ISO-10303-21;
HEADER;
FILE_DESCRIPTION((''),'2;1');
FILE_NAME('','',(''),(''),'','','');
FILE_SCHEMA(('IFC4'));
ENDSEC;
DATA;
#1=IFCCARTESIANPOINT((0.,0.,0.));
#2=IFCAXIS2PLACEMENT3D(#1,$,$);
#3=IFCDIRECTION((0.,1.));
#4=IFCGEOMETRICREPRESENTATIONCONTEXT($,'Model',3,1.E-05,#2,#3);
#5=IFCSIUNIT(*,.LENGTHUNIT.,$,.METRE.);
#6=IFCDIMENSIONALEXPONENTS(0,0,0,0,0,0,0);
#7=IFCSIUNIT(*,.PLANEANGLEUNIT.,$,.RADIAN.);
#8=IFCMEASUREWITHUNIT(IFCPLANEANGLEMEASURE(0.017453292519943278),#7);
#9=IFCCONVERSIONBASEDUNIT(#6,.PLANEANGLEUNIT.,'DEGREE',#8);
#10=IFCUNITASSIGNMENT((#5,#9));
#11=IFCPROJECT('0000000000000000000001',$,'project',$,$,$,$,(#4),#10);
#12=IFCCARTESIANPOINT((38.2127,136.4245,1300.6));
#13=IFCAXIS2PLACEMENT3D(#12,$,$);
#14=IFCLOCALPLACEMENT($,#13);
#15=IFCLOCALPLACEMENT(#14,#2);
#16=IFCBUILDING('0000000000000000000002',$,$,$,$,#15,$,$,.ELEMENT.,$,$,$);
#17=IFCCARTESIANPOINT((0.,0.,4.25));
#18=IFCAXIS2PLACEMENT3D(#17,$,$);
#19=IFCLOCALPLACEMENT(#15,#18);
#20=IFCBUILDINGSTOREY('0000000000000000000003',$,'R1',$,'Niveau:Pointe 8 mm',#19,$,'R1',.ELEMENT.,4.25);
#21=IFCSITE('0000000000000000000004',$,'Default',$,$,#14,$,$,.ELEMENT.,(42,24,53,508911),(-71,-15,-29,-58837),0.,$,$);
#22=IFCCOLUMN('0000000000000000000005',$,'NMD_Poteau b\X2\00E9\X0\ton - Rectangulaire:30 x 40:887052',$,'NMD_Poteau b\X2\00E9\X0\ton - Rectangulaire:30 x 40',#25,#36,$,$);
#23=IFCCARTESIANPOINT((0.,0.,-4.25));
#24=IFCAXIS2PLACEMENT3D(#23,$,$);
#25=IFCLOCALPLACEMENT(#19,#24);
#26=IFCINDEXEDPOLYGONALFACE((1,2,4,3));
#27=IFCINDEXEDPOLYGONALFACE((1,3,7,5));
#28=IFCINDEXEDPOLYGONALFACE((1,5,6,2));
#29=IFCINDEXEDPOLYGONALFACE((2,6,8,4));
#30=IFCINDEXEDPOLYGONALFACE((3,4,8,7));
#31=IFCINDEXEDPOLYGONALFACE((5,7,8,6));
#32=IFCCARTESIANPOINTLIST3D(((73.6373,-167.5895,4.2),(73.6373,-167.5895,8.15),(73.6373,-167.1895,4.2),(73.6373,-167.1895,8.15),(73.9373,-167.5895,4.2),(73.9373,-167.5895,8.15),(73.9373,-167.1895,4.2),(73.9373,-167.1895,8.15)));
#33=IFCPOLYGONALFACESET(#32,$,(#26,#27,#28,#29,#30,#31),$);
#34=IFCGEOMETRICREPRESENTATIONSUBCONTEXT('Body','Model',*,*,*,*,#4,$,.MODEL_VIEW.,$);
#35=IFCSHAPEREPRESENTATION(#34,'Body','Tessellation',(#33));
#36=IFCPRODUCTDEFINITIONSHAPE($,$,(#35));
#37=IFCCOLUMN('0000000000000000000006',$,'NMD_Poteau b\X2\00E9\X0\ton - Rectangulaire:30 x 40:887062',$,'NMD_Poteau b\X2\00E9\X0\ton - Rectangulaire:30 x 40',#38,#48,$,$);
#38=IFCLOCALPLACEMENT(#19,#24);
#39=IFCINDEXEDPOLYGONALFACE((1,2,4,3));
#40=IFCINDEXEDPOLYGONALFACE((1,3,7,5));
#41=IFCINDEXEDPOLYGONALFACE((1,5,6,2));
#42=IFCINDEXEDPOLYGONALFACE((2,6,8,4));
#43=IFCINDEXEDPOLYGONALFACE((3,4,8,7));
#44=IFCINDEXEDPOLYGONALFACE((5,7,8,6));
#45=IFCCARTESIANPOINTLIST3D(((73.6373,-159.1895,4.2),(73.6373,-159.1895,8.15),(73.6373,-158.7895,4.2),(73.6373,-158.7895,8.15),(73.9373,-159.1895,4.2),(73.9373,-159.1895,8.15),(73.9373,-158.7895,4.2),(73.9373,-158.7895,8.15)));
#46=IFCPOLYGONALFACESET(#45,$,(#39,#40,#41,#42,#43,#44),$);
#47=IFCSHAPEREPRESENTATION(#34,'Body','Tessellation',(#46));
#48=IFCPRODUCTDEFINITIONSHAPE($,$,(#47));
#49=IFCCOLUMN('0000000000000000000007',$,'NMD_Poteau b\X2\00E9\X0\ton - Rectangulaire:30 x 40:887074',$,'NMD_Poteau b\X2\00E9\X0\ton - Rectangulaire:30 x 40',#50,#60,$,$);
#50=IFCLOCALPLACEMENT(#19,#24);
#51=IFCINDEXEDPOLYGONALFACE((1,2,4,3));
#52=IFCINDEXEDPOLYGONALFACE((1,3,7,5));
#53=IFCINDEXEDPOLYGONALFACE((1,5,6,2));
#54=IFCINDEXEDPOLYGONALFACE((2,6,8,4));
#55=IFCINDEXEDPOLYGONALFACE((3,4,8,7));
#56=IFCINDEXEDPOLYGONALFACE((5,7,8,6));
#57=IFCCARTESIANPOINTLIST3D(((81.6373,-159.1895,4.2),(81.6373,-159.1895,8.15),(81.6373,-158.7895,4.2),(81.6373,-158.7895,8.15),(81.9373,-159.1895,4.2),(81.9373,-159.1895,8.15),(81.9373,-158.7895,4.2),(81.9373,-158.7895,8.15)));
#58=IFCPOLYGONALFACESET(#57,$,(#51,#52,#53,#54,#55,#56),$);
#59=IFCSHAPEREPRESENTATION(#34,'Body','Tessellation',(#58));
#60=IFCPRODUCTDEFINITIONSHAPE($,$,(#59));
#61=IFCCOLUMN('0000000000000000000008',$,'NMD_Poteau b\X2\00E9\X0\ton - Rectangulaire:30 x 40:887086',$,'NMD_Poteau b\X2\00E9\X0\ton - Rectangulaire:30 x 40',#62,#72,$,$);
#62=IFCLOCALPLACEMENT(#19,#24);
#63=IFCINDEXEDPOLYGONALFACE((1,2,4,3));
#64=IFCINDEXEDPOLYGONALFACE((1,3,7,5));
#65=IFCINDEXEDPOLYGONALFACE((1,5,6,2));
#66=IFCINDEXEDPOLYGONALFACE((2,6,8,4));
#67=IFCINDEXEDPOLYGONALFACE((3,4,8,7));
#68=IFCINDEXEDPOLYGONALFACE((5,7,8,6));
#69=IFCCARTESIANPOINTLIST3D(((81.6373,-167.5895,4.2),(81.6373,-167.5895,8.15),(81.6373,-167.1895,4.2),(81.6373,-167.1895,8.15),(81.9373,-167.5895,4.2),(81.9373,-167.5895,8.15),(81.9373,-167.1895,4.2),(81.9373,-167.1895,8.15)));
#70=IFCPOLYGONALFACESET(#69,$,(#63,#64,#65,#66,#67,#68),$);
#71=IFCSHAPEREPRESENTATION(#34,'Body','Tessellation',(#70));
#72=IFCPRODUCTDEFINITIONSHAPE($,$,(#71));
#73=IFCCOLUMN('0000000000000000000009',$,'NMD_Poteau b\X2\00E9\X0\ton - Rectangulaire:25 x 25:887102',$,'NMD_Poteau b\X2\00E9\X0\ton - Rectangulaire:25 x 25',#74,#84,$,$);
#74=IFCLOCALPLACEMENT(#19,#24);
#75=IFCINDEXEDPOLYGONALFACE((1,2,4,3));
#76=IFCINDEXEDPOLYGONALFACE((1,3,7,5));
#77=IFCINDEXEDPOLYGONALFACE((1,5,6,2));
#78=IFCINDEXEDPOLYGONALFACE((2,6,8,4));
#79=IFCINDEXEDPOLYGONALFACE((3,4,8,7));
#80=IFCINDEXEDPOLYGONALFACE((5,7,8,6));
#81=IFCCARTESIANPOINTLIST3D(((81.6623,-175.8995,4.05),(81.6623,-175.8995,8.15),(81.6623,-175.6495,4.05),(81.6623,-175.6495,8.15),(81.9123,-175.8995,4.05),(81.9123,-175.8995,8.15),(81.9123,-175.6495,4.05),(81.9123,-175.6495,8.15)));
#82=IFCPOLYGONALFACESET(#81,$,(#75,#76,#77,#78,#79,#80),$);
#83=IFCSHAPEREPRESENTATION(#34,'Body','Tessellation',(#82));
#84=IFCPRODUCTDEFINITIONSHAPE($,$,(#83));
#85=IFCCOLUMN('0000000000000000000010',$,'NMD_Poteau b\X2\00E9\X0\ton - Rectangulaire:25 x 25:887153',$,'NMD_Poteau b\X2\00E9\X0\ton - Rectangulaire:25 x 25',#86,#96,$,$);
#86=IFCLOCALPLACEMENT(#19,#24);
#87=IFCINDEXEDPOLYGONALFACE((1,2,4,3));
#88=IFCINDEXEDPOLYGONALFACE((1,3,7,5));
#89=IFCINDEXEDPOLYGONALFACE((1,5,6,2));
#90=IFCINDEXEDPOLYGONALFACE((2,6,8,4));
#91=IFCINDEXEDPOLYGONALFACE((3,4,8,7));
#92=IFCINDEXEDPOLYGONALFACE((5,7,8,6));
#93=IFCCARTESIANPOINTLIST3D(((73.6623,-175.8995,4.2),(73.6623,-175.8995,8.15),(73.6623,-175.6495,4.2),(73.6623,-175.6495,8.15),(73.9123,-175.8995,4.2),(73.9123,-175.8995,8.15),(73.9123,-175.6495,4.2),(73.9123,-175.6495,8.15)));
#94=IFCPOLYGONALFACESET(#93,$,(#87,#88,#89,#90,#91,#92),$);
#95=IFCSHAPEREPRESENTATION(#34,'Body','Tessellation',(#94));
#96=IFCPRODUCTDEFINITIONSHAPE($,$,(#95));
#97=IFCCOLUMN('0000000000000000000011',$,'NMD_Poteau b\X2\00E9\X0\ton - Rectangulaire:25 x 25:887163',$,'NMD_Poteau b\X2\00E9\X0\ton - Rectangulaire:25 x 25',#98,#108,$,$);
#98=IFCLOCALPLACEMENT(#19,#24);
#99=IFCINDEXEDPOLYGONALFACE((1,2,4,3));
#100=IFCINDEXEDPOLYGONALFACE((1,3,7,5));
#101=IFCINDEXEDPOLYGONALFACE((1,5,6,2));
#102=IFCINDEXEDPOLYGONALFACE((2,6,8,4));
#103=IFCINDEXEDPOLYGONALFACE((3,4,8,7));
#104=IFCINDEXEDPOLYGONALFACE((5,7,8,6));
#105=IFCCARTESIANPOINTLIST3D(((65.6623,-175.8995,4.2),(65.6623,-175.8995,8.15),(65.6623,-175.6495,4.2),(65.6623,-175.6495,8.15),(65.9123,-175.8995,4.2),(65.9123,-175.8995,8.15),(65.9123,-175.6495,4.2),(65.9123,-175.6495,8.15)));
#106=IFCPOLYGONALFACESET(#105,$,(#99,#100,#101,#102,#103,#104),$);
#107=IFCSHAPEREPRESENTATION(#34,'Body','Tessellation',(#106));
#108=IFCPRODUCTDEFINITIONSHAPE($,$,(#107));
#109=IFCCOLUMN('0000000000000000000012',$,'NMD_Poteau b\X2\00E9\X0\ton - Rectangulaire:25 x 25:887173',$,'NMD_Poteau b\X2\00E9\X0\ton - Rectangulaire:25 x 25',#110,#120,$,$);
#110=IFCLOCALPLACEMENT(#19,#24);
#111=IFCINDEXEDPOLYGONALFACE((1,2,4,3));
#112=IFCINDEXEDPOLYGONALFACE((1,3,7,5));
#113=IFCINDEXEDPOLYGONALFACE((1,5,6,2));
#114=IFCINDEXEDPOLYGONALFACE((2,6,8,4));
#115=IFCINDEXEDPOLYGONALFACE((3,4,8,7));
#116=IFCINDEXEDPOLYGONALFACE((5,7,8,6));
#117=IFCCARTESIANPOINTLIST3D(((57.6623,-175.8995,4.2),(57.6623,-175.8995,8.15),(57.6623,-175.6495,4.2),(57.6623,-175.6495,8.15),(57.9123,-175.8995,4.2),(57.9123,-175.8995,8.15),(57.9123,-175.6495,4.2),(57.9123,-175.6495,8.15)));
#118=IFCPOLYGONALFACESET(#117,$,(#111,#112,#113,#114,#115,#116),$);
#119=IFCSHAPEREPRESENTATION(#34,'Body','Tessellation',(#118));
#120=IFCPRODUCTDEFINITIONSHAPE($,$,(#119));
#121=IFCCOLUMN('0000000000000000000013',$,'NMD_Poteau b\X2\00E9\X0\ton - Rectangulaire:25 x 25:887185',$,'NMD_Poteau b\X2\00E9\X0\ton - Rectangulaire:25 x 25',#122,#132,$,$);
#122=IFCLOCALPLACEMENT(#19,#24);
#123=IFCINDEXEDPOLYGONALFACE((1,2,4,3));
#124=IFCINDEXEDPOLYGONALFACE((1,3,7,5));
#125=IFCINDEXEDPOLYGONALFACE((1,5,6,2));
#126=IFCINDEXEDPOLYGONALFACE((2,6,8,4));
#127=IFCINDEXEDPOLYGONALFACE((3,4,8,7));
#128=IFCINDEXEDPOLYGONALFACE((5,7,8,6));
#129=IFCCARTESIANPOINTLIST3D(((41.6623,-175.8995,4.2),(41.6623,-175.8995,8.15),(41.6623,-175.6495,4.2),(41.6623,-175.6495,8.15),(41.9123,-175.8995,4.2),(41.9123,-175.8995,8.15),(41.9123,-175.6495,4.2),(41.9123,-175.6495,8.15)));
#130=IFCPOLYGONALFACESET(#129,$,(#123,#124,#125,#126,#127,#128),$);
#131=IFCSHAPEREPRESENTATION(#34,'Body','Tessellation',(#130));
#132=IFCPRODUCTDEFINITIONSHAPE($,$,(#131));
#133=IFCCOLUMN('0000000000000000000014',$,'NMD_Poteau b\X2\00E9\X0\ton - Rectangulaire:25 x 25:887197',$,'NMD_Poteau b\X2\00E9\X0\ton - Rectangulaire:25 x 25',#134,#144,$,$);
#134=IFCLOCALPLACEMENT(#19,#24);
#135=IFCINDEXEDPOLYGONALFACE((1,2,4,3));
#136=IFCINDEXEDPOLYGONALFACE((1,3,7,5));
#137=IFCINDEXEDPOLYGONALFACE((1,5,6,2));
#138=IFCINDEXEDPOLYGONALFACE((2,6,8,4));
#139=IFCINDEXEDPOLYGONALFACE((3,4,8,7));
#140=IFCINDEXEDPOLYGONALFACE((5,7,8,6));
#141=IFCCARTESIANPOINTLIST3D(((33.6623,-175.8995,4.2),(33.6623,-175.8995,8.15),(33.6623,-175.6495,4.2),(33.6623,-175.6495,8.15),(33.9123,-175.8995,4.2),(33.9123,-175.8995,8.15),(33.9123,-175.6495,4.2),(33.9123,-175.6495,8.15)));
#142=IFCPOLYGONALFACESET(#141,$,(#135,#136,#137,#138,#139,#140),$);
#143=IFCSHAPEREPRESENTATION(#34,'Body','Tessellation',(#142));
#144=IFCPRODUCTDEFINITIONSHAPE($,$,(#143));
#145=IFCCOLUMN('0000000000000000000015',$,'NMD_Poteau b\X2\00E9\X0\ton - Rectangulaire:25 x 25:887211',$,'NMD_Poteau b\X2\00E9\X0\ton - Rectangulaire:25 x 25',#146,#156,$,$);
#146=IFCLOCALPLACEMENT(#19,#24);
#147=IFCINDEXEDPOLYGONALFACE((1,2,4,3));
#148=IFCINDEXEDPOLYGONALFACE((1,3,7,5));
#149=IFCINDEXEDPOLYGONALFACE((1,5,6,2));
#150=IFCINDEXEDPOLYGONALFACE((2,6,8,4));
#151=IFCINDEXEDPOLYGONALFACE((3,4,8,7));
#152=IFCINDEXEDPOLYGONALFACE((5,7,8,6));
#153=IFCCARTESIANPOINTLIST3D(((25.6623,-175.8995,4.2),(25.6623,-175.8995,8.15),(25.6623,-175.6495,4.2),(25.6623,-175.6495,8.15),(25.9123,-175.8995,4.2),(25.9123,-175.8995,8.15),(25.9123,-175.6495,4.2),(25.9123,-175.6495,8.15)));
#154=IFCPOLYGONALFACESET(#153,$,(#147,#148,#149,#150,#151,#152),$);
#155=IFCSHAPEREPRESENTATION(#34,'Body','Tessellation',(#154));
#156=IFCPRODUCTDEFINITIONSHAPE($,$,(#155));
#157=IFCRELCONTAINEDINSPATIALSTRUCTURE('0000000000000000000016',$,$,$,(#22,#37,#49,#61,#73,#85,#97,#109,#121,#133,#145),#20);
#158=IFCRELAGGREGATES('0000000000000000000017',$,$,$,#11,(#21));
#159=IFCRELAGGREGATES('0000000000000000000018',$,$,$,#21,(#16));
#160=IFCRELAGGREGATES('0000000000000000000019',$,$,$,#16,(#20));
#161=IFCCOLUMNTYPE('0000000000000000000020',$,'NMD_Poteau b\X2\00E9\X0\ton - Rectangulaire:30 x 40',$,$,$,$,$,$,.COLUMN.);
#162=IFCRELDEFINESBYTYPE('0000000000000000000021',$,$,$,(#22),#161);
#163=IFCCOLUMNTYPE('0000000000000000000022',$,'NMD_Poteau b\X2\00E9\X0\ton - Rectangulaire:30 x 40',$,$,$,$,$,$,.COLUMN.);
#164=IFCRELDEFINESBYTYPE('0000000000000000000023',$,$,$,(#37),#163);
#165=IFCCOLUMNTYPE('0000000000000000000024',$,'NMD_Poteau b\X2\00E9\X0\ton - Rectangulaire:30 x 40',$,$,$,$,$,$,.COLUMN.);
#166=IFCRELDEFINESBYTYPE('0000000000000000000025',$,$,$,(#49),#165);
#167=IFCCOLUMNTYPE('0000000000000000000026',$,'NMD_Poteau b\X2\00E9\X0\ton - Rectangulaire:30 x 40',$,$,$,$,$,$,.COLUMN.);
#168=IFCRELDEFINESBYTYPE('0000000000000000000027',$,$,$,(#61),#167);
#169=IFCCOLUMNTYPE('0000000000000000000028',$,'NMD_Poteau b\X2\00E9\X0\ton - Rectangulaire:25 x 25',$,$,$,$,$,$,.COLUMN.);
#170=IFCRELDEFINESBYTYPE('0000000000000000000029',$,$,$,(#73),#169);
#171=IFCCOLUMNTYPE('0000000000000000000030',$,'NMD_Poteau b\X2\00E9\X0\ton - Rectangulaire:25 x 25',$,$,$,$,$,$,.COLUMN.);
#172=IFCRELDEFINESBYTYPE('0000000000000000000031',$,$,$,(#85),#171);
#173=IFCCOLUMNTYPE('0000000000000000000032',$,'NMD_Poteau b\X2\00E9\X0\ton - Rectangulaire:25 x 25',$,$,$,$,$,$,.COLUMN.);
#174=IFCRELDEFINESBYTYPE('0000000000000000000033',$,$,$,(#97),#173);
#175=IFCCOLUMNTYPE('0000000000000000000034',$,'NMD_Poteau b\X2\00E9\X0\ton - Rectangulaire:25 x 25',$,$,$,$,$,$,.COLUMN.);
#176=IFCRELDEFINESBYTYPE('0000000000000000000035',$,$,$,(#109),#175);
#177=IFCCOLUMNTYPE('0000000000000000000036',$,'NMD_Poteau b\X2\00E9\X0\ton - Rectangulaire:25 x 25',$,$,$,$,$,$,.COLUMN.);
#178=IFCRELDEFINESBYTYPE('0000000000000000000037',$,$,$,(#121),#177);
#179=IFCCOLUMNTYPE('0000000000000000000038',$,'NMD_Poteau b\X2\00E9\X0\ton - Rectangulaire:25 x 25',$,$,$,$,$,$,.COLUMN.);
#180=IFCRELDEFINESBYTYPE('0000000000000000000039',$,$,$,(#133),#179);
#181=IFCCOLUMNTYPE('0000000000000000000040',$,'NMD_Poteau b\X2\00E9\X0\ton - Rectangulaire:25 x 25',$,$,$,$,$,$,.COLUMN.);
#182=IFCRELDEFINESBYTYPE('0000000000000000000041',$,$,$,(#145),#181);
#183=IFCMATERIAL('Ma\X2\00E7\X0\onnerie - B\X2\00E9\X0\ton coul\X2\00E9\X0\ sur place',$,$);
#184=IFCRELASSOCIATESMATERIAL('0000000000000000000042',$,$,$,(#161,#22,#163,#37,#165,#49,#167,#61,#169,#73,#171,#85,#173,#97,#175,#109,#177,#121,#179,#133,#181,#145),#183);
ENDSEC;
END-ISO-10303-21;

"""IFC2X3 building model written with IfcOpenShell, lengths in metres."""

from ifc_helpers import new_model, entity, si_unit, converted_unit, direction, frame, frame_2d, origin, place, context, subcontext, project, spatial, rectangle, extrude, source, transform, mapped, material, type_object, type_shapes, element, save


model = new_model("IFC2X3")

# Units and contexts
model_context = context("Model", 3, precision=1e-05, world=origin(), true_north=direction((0.0, 1.0)))
body_context = subcontext(model_context, "Body", "Model", "MODEL_VIEW")
ifc_project = project(units=[si_unit("LENGTHUNIT", "METRE"), converted_unit("PLANEANGLEUNIT", "DEGREE", entity("IfcPlaneAngleMeasure", 0.017453292519943278), si_unit("PLANEANGLEUNIT", "RADIAN"), dimensions=[0, 0, 0, 0, 0, 0, 0])], contexts=[model_context])

# Site, building, storey
site_placement = place(None, frame((38.2127, 136.4245, 1300.6)))
site = spatial("IfcSite", under=ifc_project, at=site_placement, Name="Default", CompositionType="ELEMENT", RefLatitude=(42, 24, 53, 508911), RefLongitude=(-71, -15, -29, -58837), RefElevation=0.0)
building_placement = place(site_placement, origin())
building = spatial("IfcBuilding", under=site, at=building_placement, CompositionType="ELEMENT")
storey_placement = place(building_placement, frame((0.0, 0.0, 4.25)))
storey = spatial("IfcBuildingStorey", under=building, at=storey_placement, Name="R1", ObjectType="Niveau:Pointe 8 mm", LongName="R1", CompositionType="ELEMENT", Elevation=4.25)

# Columns
ifc_material = material(Name="Maçonnerie - Béton coulé sur place")
column_type_1 = type_object("IfcColumnType", Name="NMD_Poteau béton - Rectangulaire:30 x 40", PredefinedType="COLUMN", material=ifc_material)
shared_shape_1 = source(origin(), body_context, "Body", "SweptSolid", [
    extrude(rectangle(XDim=0.3, YDim=0.4, at=frame_2d((0.0, 0.0), x_axis=(1.0, 0.0))), frame((73.7873, -167.3895, 4.2), z_axis=(0.0, 0.0, 1.0), x_axis=(-1.0, 0.0, 0.0)), (0.0, 0.0, 1.0), 3.95),
])
type_shapes(column_type_1, [shared_shape_1])
column_1_placement = place(storey_placement, frame((0.0, 0.0, -4.25)))
element("IfcColumn", 1, at=column_1_placement, inside=storey, type_object=column_type_1, material=ifc_material, Name="NMD_Poteau béton - Rectangulaire:30 x 40:887052", ObjectType="NMD_Poteau béton - Rectangulaire:30 x 40", context=body_context, shape_type="MappedRepresentation", body=[
    mapped(shared_shape_1, transform((0.0, 0.0, 0.0), scale=1.0)),
])
column_type_2 = type_object("IfcColumnType", Name="NMD_Poteau béton - Rectangulaire:30 x 40", PredefinedType="COLUMN", material=ifc_material)
shared_shape_2 = source(origin(), body_context, "Body", "SweptSolid", [
    extrude(rectangle(XDim=0.3, YDim=0.4, at=frame_2d((0.0, 0.0), x_axis=(1.0, 0.0))), frame((73.7873, -158.9895, 4.2)), (0.0, 0.0, 1.0), 3.95),
])
type_shapes(column_type_2, [shared_shape_2])
column_2_placement = place(storey_placement, frame((0.0, 0.0, -4.25)))
element("IfcColumn", 2, at=column_2_placement, inside=storey, type_object=column_type_2, material=ifc_material, Name="NMD_Poteau béton - Rectangulaire:30 x 40:887062", ObjectType="NMD_Poteau béton - Rectangulaire:30 x 40", context=body_context, shape_type="MappedRepresentation", body=[
    mapped(shared_shape_2, transform((0.0, 0.0, 0.0), scale=1.0)),
])
column_type_3 = type_object("IfcColumnType", Name="NMD_Poteau béton - Rectangulaire:30 x 40", PredefinedType="COLUMN", material=ifc_material)
shared_shape_3 = source(origin(), body_context, "Body", "SweptSolid", [
    extrude(rectangle(XDim=0.3, YDim=0.4, at=frame_2d((0.0, 0.0), x_axis=(1.0, 0.0))), frame((81.7873, -158.9895, 4.2)), (0.0, 0.0, 1.0), 3.95),
])
type_shapes(column_type_3, [shared_shape_3])
column_3_placement = place(storey_placement, frame((0.0, 0.0, -4.25)))
element("IfcColumn", 3, at=column_3_placement, inside=storey, type_object=column_type_3, material=ifc_material, Name="NMD_Poteau béton - Rectangulaire:30 x 40:887074", ObjectType="NMD_Poteau béton - Rectangulaire:30 x 40", context=body_context, shape_type="MappedRepresentation", body=[
    mapped(shared_shape_3, transform((0.0, 0.0, 0.0), scale=1.0)),
])
column_type_4 = type_object("IfcColumnType", Name="NMD_Poteau béton - Rectangulaire:30 x 40", PredefinedType="COLUMN", material=ifc_material)
shared_shape_4 = source(origin(), body_context, "Body", "SweptSolid", [
    extrude(rectangle(XDim=0.3, YDim=0.4, at=frame_2d((0.0, 0.0), x_axis=(1.0, 0.0))), frame((81.7873, -167.3895, 4.2), z_axis=(0.0, 0.0, 1.0), x_axis=(-1.0, 0.0, 0.0)), (0.0, 0.0, 1.0), 3.95),
])
type_shapes(column_type_4, [shared_shape_4])
column_4_placement = place(storey_placement, frame((0.0, 0.0, -4.25)))
element("IfcColumn", 4, at=column_4_placement, inside=storey, type_object=column_type_4, material=ifc_material, Name="NMD_Poteau béton - Rectangulaire:30 x 40:887086", ObjectType="NMD_Poteau béton - Rectangulaire:30 x 40", context=body_context, shape_type="MappedRepresentation", body=[
    mapped(shared_shape_4, transform((0.0, 0.0, 0.0), scale=1.0)),
])
column_type_5 = type_object("IfcColumnType", Name="NMD_Poteau béton - Rectangulaire:25 x 25", PredefinedType="COLUMN", material=ifc_material)
shared_shape_5 = source(origin(), body_context, "Body", "SweptSolid", [
    extrude(rectangle(XDim=0.25, YDim=0.25, at=frame_2d((0.0, 0.0), x_axis=(1.0, 0.0))), frame((81.7873, -175.7745, 4.05), z_axis=(0.0, 0.0, 1.0), x_axis=(-1.0, 0.0, 0.0)), (0.0, 0.0, 1.0), 4.1),
])
type_shapes(column_type_5, [shared_shape_5])
column_5_placement = place(storey_placement, frame((0.0, 0.0, -4.25)))
element("IfcColumn", 5, at=column_5_placement, inside=storey, type_object=column_type_5, material=ifc_material, Name="NMD_Poteau béton - Rectangulaire:25 x 25:887102", ObjectType="NMD_Poteau béton - Rectangulaire:25 x 25", context=body_context, shape_type="MappedRepresentation", body=[
    mapped(shared_shape_5, transform((0.0, 0.0, 0.0), scale=1.0)),
])
column_type_6 = type_object("IfcColumnType", Name="NMD_Poteau béton - Rectangulaire:25 x 25", PredefinedType="COLUMN", material=ifc_material)
shared_shape_6 = source(origin(), body_context, "Body", "SweptSolid", [
    extrude(rectangle(XDim=0.25, YDim=0.25, at=frame_2d((0.0, 0.0), x_axis=(1.0, 0.0))), frame((73.7873, -175.7745, 4.2), z_axis=(0.0, 0.0, 1.0), x_axis=(-1.0, 0.0, 0.0)), (0.0, 0.0, 1.0), 3.95),
])
type_shapes(column_type_6, [shared_shape_6])
column_6_placement = place(storey_placement, frame((0.0, 0.0, -4.25)))
element("IfcColumn", 6, at=column_6_placement, inside=storey, type_object=column_type_6, material=ifc_material, Name="NMD_Poteau béton - Rectangulaire:25 x 25:887153", ObjectType="NMD_Poteau béton - Rectangulaire:25 x 25", context=body_context, shape_type="MappedRepresentation", body=[
    mapped(shared_shape_6, transform((0.0, 0.0, 0.0), scale=1.0)),
])
column_type_7 = type_object("IfcColumnType", Name="NMD_Poteau béton - Rectangulaire:25 x 25", PredefinedType="COLUMN", material=ifc_material)
shared_shape_7 = source(origin(), body_context, "Body", "SweptSolid", [
    extrude(rectangle(XDim=0.25, YDim=0.25, at=frame_2d((0.0, 0.0), x_axis=(1.0, 0.0))), frame((65.7873, -175.7745, 4.2), z_axis=(0.0, 0.0, 1.0), x_axis=(-1.0, 0.0, 0.0)), (0.0, 0.0, 1.0), 3.95),
])
type_shapes(column_type_7, [shared_shape_7])
column_7_placement = place(storey_placement, frame((0.0, 0.0, -4.25)))
element("IfcColumn", 7, at=column_7_placement, inside=storey, type_object=column_type_7, material=ifc_material, Name="NMD_Poteau béton - Rectangulaire:25 x 25:887163", ObjectType="NMD_Poteau béton - Rectangulaire:25 x 25", context=body_context, shape_type="MappedRepresentation", body=[
    mapped(shared_shape_7, transform((0.0, 0.0, 0.0), scale=1.0)),
])
column_type_8 = type_object("IfcColumnType", Name="NMD_Poteau béton - Rectangulaire:25 x 25", PredefinedType="COLUMN", material=ifc_material)
shared_shape_8 = source(origin(), body_context, "Body", "SweptSolid", [
    extrude(rectangle(XDim=0.25, YDim=0.25, at=frame_2d((0.0, 0.0), x_axis=(1.0, 0.0))), frame((57.7873, -175.7745, 4.2), z_axis=(0.0, 0.0, 1.0), x_axis=(-1.0, 0.0, 0.0)), (0.0, 0.0, 1.0), 3.95),
])
type_shapes(column_type_8, [shared_shape_8])
column_8_placement = place(storey_placement, frame((0.0, 0.0, -4.25)))
element("IfcColumn", 8, at=column_8_placement, inside=storey, type_object=column_type_8, material=ifc_material, Name="NMD_Poteau béton - Rectangulaire:25 x 25:887173", ObjectType="NMD_Poteau béton - Rectangulaire:25 x 25", context=body_context, shape_type="MappedRepresentation", body=[
    mapped(shared_shape_8, transform((0.0, 0.0, 0.0), scale=1.0)),
])
column_type_9 = type_object("IfcColumnType", Name="NMD_Poteau béton - Rectangulaire:25 x 25", PredefinedType="COLUMN", material=ifc_material)
shared_shape_9 = source(origin(), body_context, "Body", "SweptSolid", [
    extrude(rectangle(XDim=0.25, YDim=0.25, at=frame_2d((0.0, 0.0), x_axis=(1.0, 0.0))), frame((41.7873, -175.7745, 4.2), z_axis=(0.0, 0.0, 1.0), x_axis=(-1.0, 0.0, 0.0)), (0.0, 0.0, 1.0), 3.95),
])
type_shapes(column_type_9, [shared_shape_9])
column_9_placement = place(storey_placement, frame((0.0, 0.0, -4.25)))
element("IfcColumn", 9, at=column_9_placement, inside=storey, type_object=column_type_9, material=ifc_material, Name="NMD_Poteau béton - Rectangulaire:25 x 25:887185", ObjectType="NMD_Poteau béton - Rectangulaire:25 x 25", context=body_context, shape_type="MappedRepresentation", body=[
    mapped(shared_shape_9, transform((0.0, 0.0, 0.0), scale=1.0)),
])
column_type_10 = type_object("IfcColumnType", Name="NMD_Poteau béton - Rectangulaire:25 x 25", PredefinedType="COLUMN", material=ifc_material)
shared_shape_10 = source(origin(), body_context, "Body", "SweptSolid", [
    extrude(rectangle(XDim=0.25, YDim=0.25, at=frame_2d((0.0, 0.0), x_axis=(1.0, 0.0))), frame((33.7873, -175.7745, 4.2), z_axis=(0.0, 0.0, 1.0), x_axis=(-1.0, 0.0, 0.0)), (0.0, 0.0, 1.0), 3.95),
])
type_shapes(column_type_10, [shared_shape_10])
column_10_placement = place(storey_placement, frame((0.0, 0.0, -4.25)))
element("IfcColumn", 10, at=column_10_placement, inside=storey, type_object=column_type_10, material=ifc_material, Name="NMD_Poteau béton - Rectangulaire:25 x 25:887197", ObjectType="NMD_Poteau béton - Rectangulaire:25 x 25", context=body_context, shape_type="MappedRepresentation", body=[
    mapped(shared_shape_10, transform((0.0, 0.0, 0.0), scale=1.0)),
])
column_type_11 = type_object("IfcColumnType", Name="NMD_Poteau béton - Rectangulaire:25 x 25", PredefinedType="COLUMN", material=ifc_material)
shared_shape_11 = source(origin(), body_context, "Body", "SweptSolid", [
    extrude(rectangle(XDim=0.25, YDim=0.25, at=frame_2d((0.0, 0.0), x_axis=(1.0, 0.0))), frame((25.7873, -175.7745, 4.2), z_axis=(0.0, 0.0, 1.0), x_axis=(-1.0, 0.0, 0.0)), (0.0, 0.0, 1.0), 3.95),
])
type_shapes(column_type_11, [shared_shape_11])
column_11_placement = place(storey_placement, frame((0.0, 0.0, -4.25)))
element("IfcColumn", 11, at=column_11_placement, inside=storey, type_object=column_type_11, material=ifc_material, Name="NMD_Poteau béton - Rectangulaire:25 x 25:887211", ObjectType="NMD_Poteau béton - Rectangulaire:25 x 25", context=body_context, shape_type="MappedRepresentation", body=[
    mapped(shared_shape_11, transform((0.0, 0.0, 0.0), scale=1.0)),
])

save(model, "model.ifc")
